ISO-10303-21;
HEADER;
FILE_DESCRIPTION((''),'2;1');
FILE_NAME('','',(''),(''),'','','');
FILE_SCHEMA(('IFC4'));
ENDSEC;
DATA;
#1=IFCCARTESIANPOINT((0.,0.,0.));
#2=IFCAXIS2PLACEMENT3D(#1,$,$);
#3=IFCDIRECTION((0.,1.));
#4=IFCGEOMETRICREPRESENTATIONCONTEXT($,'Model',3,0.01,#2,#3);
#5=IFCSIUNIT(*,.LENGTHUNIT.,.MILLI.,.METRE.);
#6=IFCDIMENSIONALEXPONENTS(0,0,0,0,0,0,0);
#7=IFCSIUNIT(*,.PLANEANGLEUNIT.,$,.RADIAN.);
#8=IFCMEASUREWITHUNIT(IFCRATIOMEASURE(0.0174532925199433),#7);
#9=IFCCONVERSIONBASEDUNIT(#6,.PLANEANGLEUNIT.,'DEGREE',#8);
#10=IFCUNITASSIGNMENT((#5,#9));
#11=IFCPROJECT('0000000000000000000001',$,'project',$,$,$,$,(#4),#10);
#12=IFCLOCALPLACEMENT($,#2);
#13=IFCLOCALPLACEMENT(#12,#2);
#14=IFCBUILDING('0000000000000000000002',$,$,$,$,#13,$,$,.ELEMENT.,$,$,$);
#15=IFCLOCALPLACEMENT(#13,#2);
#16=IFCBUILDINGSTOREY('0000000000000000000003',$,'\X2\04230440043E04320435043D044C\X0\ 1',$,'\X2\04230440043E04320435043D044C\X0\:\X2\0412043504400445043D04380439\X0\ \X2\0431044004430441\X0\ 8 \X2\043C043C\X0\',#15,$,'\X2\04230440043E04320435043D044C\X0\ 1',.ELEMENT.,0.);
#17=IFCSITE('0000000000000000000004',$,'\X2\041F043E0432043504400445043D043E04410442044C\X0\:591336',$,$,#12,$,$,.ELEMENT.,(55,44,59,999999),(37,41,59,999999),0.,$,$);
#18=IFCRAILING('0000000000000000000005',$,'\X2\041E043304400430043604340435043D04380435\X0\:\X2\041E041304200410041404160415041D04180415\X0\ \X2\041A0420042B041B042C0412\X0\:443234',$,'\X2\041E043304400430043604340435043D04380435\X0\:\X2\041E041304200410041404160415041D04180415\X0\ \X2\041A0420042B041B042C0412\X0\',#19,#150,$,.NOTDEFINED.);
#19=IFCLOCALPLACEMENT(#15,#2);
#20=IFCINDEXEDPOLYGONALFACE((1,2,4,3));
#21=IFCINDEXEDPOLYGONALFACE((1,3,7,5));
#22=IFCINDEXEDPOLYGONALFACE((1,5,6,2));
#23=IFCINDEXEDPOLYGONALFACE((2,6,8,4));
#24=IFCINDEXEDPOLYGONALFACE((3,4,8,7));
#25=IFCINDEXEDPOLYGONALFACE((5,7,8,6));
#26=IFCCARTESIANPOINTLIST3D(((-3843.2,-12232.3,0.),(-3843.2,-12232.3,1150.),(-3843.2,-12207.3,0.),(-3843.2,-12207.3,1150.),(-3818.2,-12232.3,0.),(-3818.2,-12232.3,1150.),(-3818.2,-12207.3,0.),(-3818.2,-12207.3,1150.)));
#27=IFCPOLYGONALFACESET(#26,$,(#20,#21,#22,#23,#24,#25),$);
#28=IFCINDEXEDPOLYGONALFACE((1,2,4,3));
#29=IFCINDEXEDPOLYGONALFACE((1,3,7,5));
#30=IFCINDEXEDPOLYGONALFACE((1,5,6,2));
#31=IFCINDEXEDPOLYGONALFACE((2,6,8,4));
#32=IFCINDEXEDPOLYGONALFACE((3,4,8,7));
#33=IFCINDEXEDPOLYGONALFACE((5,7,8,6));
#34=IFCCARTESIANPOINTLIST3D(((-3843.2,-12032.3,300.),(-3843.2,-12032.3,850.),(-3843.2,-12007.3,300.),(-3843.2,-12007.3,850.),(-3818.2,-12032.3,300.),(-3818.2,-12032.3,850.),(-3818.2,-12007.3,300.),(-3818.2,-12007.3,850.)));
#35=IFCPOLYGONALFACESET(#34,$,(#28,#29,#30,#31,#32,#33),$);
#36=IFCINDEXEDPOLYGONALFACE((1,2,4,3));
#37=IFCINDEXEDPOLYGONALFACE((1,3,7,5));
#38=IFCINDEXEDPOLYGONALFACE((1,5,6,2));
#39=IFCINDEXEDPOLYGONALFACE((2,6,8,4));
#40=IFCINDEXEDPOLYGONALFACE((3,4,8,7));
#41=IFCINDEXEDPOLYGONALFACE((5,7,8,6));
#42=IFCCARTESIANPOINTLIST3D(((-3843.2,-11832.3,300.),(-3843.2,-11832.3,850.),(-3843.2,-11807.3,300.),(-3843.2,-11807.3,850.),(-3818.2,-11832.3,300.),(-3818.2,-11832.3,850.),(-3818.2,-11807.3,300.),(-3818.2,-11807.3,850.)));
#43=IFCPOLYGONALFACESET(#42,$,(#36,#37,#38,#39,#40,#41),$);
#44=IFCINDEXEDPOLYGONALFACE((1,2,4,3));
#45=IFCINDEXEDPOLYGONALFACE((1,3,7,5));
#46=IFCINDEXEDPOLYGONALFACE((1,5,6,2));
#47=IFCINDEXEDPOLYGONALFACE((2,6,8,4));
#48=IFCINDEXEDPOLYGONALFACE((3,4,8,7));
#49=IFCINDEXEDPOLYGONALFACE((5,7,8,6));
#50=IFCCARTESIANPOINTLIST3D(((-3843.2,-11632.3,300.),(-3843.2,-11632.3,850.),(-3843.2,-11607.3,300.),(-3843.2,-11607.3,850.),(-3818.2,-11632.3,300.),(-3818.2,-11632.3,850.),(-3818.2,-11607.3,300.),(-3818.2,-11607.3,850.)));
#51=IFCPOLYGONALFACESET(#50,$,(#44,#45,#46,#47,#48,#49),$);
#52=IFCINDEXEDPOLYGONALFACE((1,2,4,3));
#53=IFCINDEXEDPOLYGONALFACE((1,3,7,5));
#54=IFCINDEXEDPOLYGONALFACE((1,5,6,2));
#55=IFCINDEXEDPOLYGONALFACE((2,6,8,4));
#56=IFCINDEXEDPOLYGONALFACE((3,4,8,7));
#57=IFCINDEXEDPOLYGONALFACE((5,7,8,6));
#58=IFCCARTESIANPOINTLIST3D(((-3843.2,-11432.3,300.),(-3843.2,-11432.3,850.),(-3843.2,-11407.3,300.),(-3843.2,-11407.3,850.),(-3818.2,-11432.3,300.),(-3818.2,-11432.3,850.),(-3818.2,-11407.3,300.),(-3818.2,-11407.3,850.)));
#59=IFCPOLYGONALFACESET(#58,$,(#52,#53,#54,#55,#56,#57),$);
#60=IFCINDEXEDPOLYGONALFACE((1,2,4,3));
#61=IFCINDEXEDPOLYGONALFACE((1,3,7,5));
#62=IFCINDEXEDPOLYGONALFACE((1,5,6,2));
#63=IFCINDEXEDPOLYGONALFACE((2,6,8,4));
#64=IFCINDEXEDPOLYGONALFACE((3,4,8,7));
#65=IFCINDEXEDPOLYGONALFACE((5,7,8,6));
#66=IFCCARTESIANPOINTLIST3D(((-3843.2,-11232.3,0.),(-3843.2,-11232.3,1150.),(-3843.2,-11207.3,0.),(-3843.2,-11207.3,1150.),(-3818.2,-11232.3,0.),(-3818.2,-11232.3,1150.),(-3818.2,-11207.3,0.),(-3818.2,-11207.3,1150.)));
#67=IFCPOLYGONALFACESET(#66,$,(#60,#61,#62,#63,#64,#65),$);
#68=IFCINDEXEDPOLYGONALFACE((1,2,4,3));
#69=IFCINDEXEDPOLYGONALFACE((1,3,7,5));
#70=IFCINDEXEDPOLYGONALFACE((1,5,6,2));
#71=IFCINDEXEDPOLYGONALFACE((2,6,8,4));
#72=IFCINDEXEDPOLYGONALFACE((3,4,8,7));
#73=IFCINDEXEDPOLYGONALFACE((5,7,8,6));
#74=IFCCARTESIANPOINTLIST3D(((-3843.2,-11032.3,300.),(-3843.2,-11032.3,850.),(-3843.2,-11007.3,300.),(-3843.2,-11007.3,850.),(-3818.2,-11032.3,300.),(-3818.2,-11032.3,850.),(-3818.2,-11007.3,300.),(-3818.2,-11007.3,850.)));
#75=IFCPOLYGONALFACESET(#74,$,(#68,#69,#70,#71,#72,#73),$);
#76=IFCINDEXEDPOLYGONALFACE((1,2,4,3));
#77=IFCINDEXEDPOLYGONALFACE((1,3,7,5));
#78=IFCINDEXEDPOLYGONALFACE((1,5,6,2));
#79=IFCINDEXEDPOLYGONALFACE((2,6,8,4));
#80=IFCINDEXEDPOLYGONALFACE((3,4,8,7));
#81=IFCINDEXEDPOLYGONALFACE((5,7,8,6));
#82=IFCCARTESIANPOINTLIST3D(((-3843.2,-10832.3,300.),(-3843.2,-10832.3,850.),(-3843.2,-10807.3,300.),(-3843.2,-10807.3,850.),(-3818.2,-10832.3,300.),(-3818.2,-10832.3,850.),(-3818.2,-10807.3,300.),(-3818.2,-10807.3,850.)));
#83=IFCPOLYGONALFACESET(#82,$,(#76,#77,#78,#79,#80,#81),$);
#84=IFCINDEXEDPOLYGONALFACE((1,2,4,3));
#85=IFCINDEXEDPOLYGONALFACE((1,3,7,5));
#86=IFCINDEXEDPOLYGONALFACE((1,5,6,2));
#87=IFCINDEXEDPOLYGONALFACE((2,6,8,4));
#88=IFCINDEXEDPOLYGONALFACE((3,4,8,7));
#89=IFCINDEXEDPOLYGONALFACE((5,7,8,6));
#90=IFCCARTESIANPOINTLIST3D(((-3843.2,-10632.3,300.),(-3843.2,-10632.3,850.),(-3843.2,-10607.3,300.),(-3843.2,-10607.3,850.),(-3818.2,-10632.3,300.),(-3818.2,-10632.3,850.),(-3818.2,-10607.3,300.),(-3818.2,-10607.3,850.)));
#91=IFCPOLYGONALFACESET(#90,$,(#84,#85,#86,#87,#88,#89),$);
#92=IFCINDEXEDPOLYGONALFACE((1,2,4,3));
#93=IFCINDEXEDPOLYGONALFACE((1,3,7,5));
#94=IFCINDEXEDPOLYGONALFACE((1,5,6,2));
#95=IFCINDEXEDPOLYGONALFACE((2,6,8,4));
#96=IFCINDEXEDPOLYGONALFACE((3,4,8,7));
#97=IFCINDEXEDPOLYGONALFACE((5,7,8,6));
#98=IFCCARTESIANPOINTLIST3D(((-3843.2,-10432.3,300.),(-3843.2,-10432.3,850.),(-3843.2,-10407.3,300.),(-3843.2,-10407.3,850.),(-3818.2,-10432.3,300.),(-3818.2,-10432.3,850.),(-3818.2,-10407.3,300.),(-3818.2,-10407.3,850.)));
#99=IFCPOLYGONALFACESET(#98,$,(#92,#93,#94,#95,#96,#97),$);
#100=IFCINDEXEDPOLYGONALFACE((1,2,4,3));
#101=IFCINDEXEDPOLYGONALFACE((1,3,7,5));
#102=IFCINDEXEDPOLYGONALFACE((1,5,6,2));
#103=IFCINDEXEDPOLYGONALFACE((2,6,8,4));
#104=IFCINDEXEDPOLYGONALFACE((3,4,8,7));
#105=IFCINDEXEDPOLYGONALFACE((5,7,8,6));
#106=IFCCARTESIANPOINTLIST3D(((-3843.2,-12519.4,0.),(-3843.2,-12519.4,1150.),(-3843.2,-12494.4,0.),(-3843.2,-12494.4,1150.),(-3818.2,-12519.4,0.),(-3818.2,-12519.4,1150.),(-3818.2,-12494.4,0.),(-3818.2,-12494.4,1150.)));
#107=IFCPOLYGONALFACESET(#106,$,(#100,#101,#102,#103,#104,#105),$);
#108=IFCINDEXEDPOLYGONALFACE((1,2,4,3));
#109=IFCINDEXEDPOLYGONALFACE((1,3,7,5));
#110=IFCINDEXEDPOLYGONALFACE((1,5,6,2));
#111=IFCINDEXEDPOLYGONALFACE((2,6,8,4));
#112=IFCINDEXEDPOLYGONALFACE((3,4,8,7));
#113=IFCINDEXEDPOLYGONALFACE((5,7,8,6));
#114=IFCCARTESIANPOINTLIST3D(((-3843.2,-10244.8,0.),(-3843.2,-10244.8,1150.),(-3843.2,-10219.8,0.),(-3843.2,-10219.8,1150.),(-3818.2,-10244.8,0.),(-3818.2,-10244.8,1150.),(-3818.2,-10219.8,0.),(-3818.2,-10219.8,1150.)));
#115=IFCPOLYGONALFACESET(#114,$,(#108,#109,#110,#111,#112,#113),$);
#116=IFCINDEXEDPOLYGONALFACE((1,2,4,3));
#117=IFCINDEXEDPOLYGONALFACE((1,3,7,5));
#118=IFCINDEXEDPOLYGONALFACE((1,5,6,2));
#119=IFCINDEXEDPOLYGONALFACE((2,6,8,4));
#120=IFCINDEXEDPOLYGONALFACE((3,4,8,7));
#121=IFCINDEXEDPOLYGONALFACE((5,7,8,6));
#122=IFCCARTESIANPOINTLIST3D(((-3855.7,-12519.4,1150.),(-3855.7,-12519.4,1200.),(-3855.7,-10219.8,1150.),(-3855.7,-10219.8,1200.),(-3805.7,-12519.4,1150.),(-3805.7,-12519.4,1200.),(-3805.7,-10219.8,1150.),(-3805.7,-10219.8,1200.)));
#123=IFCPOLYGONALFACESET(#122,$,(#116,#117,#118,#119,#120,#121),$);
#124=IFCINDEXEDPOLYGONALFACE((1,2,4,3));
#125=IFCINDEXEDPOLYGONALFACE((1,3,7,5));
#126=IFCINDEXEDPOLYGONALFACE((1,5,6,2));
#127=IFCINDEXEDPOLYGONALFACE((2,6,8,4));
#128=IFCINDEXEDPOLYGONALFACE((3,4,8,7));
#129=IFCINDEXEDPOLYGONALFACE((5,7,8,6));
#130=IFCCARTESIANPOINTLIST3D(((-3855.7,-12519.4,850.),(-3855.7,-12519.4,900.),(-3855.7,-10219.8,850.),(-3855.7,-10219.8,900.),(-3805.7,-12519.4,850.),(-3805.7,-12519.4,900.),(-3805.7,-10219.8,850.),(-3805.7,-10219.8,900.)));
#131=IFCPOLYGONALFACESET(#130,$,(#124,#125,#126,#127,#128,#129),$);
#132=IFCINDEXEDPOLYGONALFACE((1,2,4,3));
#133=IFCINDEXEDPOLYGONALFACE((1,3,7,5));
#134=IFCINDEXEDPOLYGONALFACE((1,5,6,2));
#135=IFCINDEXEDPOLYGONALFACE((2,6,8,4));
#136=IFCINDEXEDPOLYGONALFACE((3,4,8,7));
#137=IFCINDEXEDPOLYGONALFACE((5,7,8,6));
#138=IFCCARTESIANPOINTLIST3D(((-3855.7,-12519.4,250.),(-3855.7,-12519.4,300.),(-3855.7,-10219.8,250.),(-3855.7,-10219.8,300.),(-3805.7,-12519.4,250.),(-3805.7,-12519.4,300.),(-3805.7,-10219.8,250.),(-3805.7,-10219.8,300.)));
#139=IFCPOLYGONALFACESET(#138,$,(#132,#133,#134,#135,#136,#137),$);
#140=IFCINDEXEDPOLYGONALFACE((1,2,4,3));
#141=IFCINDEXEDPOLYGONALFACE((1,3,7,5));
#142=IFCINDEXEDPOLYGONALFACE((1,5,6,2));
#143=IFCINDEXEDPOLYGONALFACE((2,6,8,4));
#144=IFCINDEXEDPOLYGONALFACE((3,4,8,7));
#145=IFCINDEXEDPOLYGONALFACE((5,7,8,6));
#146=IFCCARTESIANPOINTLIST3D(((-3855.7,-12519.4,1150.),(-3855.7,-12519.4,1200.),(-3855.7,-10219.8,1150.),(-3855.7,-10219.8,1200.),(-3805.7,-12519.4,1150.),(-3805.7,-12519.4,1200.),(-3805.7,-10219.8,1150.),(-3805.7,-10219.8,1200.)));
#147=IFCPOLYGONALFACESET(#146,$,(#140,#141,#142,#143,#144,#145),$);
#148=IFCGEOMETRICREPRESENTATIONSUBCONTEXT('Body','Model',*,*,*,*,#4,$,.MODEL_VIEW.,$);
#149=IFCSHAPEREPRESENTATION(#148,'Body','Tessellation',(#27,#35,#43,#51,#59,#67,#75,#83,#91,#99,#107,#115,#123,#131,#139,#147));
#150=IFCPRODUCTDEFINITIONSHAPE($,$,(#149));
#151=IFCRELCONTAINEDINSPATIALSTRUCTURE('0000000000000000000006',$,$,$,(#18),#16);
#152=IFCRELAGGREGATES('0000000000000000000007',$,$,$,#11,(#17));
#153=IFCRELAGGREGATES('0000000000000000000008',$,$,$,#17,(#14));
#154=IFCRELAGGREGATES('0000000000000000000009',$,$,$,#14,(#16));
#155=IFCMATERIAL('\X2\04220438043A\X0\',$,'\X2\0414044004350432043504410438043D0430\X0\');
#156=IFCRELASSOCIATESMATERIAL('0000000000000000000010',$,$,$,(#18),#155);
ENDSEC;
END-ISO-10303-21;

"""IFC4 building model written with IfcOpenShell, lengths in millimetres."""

from ifc_helpers import new_model, entity, si_unit, converted_unit, direction, frame, origin, place, context, subcontext, project, spatial, indexed_curve, outline, extrude, material, element, save


model = new_model("IFC4")

# Units and contexts
model_context = context("Model", 3, precision=0.01, world=origin(), true_north=direction((0.0, 1.0)))
body_context = subcontext(model_context, "Body", "Model", "MODEL_VIEW")
ifc_project = project(units=[si_unit("LENGTHUNIT", "METRE", prefix="MILLI"), converted_unit("PLANEANGLEUNIT", "DEGREE", entity("IfcRatioMeasure", 0.0174532925199433), si_unit("PLANEANGLEUNIT", "RADIAN"), dimensions=[0, 0, 0, 0, 0, 0, 0])], contexts=[model_context])

# Site, building, storey
site_placement = place(None, origin())
site = spatial("IfcSite", under=ifc_project, at=site_placement, Name="Поверхность:591336", CompositionType="ELEMENT", RefLatitude=(55, 44, 59, 999999), RefLongitude=(37, 41, 59, 999999), RefElevation=0.0)
building_placement = place(site_placement, origin())
building = spatial("IfcBuilding", under=site, at=building_placement, CompositionType="ELEMENT")
storey_placement = place(building_placement, origin())
storey = spatial("IfcBuildingStorey", under=building, at=storey_placement, Name="Уровень 1", ObjectType="Уровень:Верхний брус 8 мм", LongName="Уровень 1", CompositionType="ELEMENT", Elevation=0.0)

# Railing
ifc_material_1 = material(Name="Тик", Category="Древесина")
railing_1_placement = place(storey_placement, origin())
element("IfcRailing", 1, at=railing_1_placement, inside=storey, material=ifc_material_1, Name="Ограждение:ОГРАДЖЕНИЕ КРЫЛЬВ:443234", ObjectType="Ограждение:ОГРАДЖЕНИЕ КРЫЛЬВ", PredefinedType="NOTDEFINED", context=body_context, shape_type="SweptSolid", body=[
    extrude(outline(indexed_curve([(-12.5, -12.5), (12.5, -12.5), (12.5, 12.5), (-12.5, 12.5), (-12.5, -12.5)], self_intersect=False)), frame((-3830.7, -12219.8, 0.0), z_axis=(0.0, 0.0, 1.0), x_axis=(0.0, -1.0, 0.0)), (0.0, 0.0, 1.0), 1150.0),
    extrude(outline(indexed_curve([(-12.5, -12.5), (12.5, -12.5), (12.5, 12.5), (-12.5, 12.5), (-12.5, -12.5)], self_intersect=False)), frame((-3830.7, -12019.8, 300.0), z_axis=(0.0, 0.0, 1.0), x_axis=(0.0, -1.0, 0.0)), (0.0, 0.0, 1.0), 550.0),
    extrude(outline(indexed_curve([(-12.5, -12.5), (12.5, -12.5), (12.5, 12.5), (-12.5, 12.5), (-12.5, -12.5)], self_intersect=False)), frame((-3830.7, -11819.8, 300.0), z_axis=(0.0, 0.0, 1.0), x_axis=(0.0, -1.0, 0.0)), (0.0, 0.0, 1.0), 550.0),
    extrude(outline(indexed_curve([(-12.5, -12.5), (12.5, -12.5), (12.5, 12.5), (-12.5, 12.5), (-12.5, -12.5)], self_intersect=False)), frame((-3830.7, -11619.8, 300.0), z_axis=(0.0, 0.0, 1.0), x_axis=(0.0, -1.0, 0.0)), (0.0, 0.0, 1.0), 550.0),
    extrude(outline(indexed_curve([(-12.5, -12.5), (12.5, -12.5), (12.5, 12.5), (-12.5, 12.5), (-12.5, -12.5)], self_intersect=False)), frame((-3830.7, -11419.8, 300.0), z_axis=(0.0, 0.0, 1.0), x_axis=(0.0, -1.0, 0.0)), (0.0, 0.0, 1.0), 550.0),
    extrude(outline(indexed_curve([(-12.5, -12.5), (12.5, -12.5), (12.5, 12.5), (-12.5, 12.5), (-12.5, -12.5)], self_intersect=False)), frame((-3830.7, -11219.8, 0.0), z_axis=(0.0, 0.0, 1.0), x_axis=(0.0, -1.0, 0.0)), (0.0, 0.0, 1.0), 1150.0),
    extrude(outline(indexed_curve([(-12.5, -12.5), (12.5, -12.5), (12.5, 12.5), (-12.5, 12.5), (-12.5, -12.5)], self_intersect=False)), frame((-3830.7, -11019.8, 300.0), z_axis=(0.0, 0.0, 1.0), x_axis=(0.0, -1.0, 0.0)), (0.0, 0.0, 1.0), 550.0),
    extrude(outline(indexed_curve([(-12.5, -12.5), (12.5, -12.5), (12.5, 12.5), (-12.5, 12.5), (-12.5, -12.5)], self_intersect=False)), frame((-3830.7, -10819.8, 300.0), z_axis=(0.0, 0.0, 1.0), x_axis=(0.0, -1.0, 0.0)), (0.0, 0.0, 1.0), 550.0),
    extrude(outline(indexed_curve([(-12.5, -12.5), (12.5, -12.5), (12.5, 12.5), (-12.5, 12.5), (-12.5, -12.5)], self_intersect=False)), frame((-3830.7, -10619.8, 300.0), z_axis=(0.0, 0.0, 1.0), x_axis=(0.0, -1.0, 0.0)), (0.0, 0.0, 1.0), 550.0),
    extrude(outline(indexed_curve([(-12.5, -12.5), (12.5, -12.5), (12.5, 12.5), (-12.5, 12.5), (-12.5, -12.5)], self_intersect=False)), frame((-3830.7, -10419.8, 300.0), z_axis=(0.0, 0.0, 1.0), x_axis=(0.0, -1.0, 0.0)), (0.0, 0.0, 1.0), 550.0),
    extrude(outline(indexed_curve([(-12.5, -12.5), (12.5, -12.5), (12.5, 12.5), (-12.5, 12.5), (-12.5, -12.5)], self_intersect=False)), frame((-3830.7, -12506.9, 0.0), z_axis=(0.0, 0.0, 1.0), x_axis=(0.0, -1.0, 0.0)), (0.0, 0.0, 1.0), 1150.0),
    extrude(outline(indexed_curve([(-12.5, -12.5), (12.5, -12.5), (12.5, 12.5), (-12.5, 12.5), (-12.5, -12.5)], self_intersect=False)), frame((-3830.7, -10232.3, 0.0), z_axis=(0.0, 0.0, 1.0), x_axis=(0.0, -1.0, 0.0)), (0.0, 0.0, 1.0), 1150.0),
    extrude(outline(indexed_curve([(-1149.8, -25.0), (1149.8, -25.0), (1149.8, 25.0), (-1149.8, 25.0), (-1149.8, -25.0)], self_intersect=False)), frame((-3830.7, -11369.6, 1150.0), z_axis=(0.0, 0.0, 1.0), x_axis=(0.0, -1.0, 0.0)), (0.0, 0.0, 1.0), 50.0),
    extrude(outline(indexed_curve([(-1149.8, -25.0), (1149.8, -25.0), (1149.8, 25.0), (-1149.8, 25.0), (-1149.8, -25.0)], self_intersect=False)), frame((-3830.7, -11369.6, 850.0), z_axis=(0.0, 0.0, 1.0), x_axis=(0.0, -1.0, 0.0)), (0.0, 0.0, 1.0), 50.0),
    extrude(outline(indexed_curve([(-1149.8, -25.0), (1149.8, -25.0), (1149.8, 25.0), (-1149.8, 25.0), (-1149.8, -25.0)], self_intersect=False)), frame((-3830.7, -11369.6, 250.0), z_axis=(0.0, 0.0, 1.0), x_axis=(0.0, -1.0, 0.0)), (0.0, 0.0, 1.0), 50.0),
    extrude(outline(indexed_curve([(-1149.8, -25.0), (1149.8, -25.0), (1149.8, 25.0), (-1149.8, 25.0), (-1149.8, -25.0)], self_intersect=False)), frame((-3830.7, -11369.6, 1150.0), z_axis=(0.0, 0.0, 1.0), x_axis=(0.0, -1.0, 0.0)), (0.0, 0.0, 1.0), 50.0),
])

save(model, "model.ifc")
